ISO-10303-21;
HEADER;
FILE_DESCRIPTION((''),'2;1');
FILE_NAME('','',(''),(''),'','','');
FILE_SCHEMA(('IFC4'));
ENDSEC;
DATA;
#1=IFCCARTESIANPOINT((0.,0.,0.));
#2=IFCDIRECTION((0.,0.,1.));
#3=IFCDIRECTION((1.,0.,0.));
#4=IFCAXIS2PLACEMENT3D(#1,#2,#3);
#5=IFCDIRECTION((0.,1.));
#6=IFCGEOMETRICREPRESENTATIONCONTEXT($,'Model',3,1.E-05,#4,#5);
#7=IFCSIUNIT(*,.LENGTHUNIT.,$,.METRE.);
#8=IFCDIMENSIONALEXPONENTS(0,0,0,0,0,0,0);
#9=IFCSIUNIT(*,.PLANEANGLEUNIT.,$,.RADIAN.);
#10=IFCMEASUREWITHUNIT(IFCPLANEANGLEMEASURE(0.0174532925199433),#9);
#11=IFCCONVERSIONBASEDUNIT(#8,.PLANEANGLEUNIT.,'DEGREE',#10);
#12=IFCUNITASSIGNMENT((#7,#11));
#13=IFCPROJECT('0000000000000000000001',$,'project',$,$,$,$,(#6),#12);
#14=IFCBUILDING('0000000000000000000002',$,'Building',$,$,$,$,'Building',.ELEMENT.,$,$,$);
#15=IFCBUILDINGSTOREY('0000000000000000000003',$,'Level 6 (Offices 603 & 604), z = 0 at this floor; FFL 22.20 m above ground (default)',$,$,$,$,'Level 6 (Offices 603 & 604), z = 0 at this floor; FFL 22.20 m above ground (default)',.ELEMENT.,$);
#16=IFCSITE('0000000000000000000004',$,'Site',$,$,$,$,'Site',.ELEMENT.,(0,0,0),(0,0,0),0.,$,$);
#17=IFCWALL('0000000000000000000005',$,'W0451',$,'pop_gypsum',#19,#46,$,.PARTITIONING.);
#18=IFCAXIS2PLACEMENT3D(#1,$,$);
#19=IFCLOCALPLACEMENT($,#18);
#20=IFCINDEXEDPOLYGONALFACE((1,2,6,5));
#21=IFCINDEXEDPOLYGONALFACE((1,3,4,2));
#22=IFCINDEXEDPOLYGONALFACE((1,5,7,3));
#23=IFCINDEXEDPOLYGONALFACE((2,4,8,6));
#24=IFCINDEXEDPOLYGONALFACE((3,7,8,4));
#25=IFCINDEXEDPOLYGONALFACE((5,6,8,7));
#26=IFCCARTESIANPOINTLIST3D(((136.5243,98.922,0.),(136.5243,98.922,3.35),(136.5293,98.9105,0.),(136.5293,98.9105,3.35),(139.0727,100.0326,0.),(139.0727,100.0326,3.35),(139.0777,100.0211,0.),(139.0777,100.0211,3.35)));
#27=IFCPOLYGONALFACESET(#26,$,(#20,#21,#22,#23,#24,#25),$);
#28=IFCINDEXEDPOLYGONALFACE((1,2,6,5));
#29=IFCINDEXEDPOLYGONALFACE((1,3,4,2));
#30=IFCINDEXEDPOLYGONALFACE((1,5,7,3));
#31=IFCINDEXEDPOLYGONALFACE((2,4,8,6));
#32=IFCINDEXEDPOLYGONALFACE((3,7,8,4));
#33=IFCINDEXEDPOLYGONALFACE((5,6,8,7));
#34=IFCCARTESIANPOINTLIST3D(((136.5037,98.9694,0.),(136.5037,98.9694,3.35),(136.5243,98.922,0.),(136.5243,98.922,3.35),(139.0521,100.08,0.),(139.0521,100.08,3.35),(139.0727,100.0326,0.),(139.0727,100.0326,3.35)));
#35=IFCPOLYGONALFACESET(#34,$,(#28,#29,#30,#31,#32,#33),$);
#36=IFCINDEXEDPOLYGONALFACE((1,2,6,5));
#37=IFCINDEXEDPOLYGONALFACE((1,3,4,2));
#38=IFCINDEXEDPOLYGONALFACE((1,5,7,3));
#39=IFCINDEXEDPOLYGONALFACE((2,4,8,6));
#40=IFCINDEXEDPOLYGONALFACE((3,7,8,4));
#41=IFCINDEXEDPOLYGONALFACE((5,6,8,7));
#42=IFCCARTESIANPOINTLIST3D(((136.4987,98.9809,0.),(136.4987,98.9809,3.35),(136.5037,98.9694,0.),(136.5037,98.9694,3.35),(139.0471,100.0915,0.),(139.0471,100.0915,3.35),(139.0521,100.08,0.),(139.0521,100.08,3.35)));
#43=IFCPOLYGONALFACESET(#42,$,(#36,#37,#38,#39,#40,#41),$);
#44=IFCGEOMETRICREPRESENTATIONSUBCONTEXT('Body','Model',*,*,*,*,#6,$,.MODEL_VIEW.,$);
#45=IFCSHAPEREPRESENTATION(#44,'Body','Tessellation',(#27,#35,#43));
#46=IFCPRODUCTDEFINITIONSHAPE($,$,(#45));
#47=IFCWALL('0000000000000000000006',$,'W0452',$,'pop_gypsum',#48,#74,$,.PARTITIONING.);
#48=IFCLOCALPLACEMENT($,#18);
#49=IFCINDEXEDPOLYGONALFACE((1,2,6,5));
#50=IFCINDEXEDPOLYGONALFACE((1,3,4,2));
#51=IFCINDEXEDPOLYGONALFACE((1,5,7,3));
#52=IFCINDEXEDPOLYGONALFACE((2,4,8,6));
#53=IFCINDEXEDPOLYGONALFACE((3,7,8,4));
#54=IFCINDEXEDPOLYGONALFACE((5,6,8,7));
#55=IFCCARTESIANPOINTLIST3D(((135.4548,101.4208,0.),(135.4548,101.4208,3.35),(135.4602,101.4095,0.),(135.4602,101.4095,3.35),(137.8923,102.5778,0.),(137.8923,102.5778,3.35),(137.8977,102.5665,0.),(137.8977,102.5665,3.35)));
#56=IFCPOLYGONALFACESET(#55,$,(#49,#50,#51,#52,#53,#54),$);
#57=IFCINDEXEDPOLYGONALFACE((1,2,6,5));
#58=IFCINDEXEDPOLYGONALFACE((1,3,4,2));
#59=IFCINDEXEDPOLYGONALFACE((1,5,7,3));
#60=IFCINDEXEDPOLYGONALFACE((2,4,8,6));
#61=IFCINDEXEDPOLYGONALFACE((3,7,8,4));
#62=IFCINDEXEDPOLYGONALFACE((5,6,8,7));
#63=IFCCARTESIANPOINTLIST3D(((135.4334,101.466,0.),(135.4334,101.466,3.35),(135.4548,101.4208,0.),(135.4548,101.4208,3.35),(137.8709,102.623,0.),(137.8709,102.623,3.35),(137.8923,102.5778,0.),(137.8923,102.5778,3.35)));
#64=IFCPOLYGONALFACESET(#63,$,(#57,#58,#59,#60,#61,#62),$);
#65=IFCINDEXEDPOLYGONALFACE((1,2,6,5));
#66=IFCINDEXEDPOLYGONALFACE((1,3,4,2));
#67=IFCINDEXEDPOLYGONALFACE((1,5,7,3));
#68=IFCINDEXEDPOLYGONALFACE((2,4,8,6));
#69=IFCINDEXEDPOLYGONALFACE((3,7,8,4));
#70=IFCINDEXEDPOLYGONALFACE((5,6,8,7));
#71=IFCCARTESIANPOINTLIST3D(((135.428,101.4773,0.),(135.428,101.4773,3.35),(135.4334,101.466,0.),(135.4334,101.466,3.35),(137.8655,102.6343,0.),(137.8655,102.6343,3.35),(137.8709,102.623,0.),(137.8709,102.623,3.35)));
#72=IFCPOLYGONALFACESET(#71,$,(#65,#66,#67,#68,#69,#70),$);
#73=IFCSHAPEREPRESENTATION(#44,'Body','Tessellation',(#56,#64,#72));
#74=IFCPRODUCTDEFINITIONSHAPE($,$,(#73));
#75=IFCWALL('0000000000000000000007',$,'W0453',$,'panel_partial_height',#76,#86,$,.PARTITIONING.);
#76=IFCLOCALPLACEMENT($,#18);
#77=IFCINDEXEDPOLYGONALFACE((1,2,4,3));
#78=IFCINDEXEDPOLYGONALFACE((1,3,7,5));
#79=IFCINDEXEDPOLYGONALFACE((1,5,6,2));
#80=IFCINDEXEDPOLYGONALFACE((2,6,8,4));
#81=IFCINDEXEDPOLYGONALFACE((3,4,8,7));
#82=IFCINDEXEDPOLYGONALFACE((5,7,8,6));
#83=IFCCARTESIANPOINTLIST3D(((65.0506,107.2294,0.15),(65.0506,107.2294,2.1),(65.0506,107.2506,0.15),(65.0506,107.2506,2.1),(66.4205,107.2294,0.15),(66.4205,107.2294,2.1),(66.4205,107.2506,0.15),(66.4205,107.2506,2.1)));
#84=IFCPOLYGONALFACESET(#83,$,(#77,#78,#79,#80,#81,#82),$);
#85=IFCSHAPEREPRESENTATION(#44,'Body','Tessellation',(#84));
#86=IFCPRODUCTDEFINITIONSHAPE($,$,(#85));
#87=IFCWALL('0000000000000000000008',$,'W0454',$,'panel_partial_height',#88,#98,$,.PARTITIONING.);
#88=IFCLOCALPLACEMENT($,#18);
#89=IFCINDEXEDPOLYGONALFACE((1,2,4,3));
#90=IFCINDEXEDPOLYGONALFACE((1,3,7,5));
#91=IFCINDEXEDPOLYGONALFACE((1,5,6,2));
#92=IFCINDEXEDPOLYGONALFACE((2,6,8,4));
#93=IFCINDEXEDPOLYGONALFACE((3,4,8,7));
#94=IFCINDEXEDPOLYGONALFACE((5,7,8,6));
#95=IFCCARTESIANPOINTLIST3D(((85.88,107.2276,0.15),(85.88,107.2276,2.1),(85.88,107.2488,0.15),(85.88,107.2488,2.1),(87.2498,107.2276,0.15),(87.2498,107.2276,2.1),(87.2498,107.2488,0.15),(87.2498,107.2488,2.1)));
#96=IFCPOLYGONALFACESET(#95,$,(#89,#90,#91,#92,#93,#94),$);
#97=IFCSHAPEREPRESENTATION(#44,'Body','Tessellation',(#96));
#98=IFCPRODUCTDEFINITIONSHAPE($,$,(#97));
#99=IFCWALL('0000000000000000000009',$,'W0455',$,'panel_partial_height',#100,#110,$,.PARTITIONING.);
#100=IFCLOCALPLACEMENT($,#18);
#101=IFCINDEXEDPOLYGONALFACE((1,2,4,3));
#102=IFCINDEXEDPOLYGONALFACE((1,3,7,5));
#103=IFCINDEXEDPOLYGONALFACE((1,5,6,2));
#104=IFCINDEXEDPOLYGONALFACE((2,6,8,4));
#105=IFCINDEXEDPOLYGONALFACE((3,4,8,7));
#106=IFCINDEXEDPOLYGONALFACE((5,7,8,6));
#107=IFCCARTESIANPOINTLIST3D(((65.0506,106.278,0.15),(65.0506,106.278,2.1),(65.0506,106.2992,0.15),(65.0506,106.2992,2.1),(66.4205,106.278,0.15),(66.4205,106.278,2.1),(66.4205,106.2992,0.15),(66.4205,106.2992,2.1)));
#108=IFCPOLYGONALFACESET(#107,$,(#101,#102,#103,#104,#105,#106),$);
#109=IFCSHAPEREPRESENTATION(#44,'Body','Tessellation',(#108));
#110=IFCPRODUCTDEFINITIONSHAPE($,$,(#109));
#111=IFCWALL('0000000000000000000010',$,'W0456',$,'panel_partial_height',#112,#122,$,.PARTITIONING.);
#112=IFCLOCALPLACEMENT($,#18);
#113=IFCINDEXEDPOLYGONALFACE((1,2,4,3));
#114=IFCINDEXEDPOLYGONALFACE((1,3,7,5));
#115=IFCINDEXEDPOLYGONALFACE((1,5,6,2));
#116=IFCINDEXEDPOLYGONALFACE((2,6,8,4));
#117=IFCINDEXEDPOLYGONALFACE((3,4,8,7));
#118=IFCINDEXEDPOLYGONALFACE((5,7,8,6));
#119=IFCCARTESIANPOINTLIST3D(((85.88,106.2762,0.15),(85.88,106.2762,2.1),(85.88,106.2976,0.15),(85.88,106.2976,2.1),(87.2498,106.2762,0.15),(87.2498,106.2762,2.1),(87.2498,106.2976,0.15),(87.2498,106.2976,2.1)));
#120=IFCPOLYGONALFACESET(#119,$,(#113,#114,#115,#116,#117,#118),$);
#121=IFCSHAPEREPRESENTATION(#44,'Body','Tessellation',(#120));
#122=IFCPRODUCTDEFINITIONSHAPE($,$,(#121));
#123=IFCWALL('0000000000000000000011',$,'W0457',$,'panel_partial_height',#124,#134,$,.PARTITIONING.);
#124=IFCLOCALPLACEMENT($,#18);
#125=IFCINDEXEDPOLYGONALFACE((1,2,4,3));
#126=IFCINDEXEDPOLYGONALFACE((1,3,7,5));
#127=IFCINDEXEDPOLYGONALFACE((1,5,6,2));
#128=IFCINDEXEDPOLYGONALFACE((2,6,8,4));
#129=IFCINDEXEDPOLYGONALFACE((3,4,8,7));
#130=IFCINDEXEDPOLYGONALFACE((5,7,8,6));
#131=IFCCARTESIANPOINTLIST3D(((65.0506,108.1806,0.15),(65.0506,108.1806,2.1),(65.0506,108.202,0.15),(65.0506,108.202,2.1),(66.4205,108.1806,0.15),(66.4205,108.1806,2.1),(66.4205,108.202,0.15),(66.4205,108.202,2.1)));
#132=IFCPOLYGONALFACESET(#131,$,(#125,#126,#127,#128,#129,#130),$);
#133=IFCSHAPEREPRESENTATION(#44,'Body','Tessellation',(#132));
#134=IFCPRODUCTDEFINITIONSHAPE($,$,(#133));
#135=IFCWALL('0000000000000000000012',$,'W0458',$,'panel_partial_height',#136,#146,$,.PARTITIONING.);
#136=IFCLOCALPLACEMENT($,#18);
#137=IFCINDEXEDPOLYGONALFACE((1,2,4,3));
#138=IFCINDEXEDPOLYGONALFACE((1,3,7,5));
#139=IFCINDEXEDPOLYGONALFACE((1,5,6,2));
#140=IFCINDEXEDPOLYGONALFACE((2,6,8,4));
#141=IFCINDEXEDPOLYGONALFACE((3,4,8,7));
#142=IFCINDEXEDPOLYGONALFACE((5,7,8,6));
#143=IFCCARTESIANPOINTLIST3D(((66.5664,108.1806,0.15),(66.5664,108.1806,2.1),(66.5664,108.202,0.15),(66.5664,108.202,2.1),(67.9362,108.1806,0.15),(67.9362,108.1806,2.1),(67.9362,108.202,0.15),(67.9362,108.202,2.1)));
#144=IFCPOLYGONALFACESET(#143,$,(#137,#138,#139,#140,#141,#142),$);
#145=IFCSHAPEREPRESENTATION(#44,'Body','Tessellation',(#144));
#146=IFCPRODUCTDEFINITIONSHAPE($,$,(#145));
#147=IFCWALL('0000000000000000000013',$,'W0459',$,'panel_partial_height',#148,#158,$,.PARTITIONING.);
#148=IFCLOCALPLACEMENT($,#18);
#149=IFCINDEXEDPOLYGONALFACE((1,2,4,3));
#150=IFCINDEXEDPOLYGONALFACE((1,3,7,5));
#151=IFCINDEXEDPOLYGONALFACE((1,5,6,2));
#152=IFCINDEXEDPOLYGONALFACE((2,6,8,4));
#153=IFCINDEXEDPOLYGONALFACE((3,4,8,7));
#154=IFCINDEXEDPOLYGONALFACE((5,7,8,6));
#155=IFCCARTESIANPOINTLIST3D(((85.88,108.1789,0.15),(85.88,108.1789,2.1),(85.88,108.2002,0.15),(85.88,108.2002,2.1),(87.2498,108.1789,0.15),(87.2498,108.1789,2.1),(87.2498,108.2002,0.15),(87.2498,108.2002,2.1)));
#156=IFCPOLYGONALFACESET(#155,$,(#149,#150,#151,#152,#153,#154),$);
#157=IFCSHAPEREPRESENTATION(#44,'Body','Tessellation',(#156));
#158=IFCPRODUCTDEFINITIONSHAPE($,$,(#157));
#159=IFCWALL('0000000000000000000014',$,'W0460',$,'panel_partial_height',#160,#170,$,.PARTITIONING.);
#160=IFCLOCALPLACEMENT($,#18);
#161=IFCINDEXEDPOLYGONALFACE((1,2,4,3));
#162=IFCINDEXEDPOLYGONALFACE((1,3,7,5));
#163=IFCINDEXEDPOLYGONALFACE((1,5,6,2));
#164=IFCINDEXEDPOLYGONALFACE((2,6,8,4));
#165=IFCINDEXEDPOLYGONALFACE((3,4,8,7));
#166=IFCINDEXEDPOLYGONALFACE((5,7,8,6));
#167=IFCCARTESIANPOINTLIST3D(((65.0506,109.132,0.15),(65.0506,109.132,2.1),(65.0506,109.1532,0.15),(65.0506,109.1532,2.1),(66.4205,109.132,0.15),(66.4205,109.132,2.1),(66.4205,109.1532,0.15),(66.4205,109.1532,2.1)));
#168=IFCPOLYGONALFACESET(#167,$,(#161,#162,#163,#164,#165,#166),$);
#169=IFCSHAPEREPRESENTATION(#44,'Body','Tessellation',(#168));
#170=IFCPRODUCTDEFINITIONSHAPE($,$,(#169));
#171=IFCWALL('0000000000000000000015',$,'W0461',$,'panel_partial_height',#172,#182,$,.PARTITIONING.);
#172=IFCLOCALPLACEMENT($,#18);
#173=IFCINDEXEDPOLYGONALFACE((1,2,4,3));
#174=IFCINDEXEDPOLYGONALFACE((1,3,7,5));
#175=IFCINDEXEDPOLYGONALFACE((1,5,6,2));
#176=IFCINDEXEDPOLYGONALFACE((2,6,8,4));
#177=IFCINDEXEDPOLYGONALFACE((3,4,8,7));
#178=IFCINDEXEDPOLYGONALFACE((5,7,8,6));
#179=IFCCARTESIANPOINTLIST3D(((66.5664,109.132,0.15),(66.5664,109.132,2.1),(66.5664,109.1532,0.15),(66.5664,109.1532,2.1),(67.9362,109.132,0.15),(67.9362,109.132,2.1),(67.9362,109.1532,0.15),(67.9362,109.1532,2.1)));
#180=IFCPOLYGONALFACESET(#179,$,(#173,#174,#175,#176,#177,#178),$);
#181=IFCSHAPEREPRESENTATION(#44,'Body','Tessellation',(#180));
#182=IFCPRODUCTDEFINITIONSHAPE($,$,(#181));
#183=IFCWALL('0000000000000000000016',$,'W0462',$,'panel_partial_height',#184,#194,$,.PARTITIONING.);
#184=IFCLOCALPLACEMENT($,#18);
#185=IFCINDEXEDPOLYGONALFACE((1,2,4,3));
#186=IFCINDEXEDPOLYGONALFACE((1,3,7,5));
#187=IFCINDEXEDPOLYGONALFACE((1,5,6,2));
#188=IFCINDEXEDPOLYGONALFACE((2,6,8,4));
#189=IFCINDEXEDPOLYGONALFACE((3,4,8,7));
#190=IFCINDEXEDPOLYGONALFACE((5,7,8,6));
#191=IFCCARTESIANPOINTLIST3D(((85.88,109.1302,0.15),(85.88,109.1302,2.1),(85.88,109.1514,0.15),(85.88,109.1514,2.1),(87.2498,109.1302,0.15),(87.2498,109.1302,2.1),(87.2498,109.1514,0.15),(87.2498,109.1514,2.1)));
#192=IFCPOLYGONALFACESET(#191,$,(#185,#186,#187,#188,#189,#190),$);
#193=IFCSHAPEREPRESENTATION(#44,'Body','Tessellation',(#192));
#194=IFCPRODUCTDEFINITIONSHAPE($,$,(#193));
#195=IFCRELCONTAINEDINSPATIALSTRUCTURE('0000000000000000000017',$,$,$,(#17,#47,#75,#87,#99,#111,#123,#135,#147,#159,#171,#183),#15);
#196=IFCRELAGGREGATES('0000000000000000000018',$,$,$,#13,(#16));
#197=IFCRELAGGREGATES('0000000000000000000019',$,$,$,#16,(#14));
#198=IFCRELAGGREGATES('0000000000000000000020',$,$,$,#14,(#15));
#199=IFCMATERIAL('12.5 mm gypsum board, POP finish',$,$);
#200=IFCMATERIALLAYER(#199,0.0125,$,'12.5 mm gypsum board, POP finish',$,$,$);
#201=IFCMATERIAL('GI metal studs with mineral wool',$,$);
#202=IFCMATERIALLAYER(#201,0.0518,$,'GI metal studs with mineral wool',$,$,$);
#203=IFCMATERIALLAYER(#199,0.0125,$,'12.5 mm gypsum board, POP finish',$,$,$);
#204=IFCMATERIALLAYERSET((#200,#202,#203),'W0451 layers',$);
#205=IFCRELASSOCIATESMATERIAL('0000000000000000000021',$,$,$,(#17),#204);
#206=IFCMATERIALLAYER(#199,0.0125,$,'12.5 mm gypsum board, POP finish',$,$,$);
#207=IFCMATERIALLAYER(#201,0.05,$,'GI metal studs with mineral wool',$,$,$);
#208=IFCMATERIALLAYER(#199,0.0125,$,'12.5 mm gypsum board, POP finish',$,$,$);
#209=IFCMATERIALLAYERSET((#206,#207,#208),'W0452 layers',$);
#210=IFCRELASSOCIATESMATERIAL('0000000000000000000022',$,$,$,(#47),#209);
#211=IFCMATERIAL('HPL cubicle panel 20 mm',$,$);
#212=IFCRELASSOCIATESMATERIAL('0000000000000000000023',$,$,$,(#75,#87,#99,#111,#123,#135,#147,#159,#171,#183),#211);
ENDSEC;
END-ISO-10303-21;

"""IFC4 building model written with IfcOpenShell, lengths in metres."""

from ifc_helpers import new_model, entity, si_unit, converted_unit, direction, frame, frame_2d, origin_with_axes, origin_2d_with_axis, place, context, subcontext, project, spatial, rectangle, extrude, material, layer, layer_set, layer_usage, element, save


model = new_model("IFC4")

# Units and contexts
model_context = context("Model", 3, precision=1e-05, world=origin_with_axes(), true_north=direction((0.0, 1.0)))
body_context = subcontext(model_context, "Body", "Model", "MODEL_VIEW")
ifc_project = project(units=[si_unit("LENGTHUNIT", "METRE"), converted_unit("PLANEANGLEUNIT", "DEGREE", entity("IfcPlaneAngleMeasure", 0.0174532925199433), si_unit("PLANEANGLEUNIT", "RADIAN"), dimensions=[0, 0, 0, 0, 0, 0, 0])], contexts=[model_context])

# Site, building, storey
site = spatial("IfcSite", under=ifc_project, Name="Site", LongName="Site", CompositionType="ELEMENT", RefLatitude=(0, 0, 0), RefLongitude=(0, 0, 0), RefElevation=0.0)
building = spatial("IfcBuilding", under=site, Name="Building", LongName="Building", CompositionType="ELEMENT")
storey = spatial("IfcBuildingStorey", under=building, Name="Level 6 (Offices 603 & 604), z = 0 at this floor; FFL 22.20 m above ground (default)", LongName="Level 6 (Offices 603 & 604), z = 0 at this floor; FFL 22.20 m above ground (default)", CompositionType="ELEMENT")

# Walls
ifc_material_1 = material(Name="12.5 mm gypsum board, POP finish")
ifc_layer_1 = layer(ifc_material_1, 0.0125, Name="12.5 mm gypsum board, POP finish")
ifc_material_2 = material(Name="GI metal studs with mineral wool")
ifc_layer_2 = layer(ifc_material_2, 0.0518, Name="GI metal studs with mineral wool")
ifc_layer_3 = layer(ifc_material_1, 0.0125, Name="12.5 mm gypsum board, POP finish")
ifc_layer_set_1 = layer_set([ifc_layer_1, ifc_layer_2, ifc_layer_3], Name="W0451 layers")
ifc_layer_usage_1 = layer_usage(ifc_layer_set_1, "AXIS2", "POSITIVE", -0.0384)
placement = place(None, origin_with_axes())
element("IfcWall", 1, at=placement, inside=storey, material=ifc_layer_usage_1, Name="W0451", ObjectType="pop_gypsum", PredefinedType="PARTITIONING", context=body_context, shape_type="SweptSolid", body=[
    extrude(rectangle(XDim=2.7799, YDim=0.0125, at=frame_2d((0.0, 0.0), x_axis=(0.916728, 0.399513))), frame((137.801, 99.4715, 0.0), z_axis=(0.0, 0.0, 1.0), x_axis=(1.0, 0.0, 0.0)), (0.0, 0.0, 1.0), 3.35),
    extrude(rectangle(XDim=2.7799, YDim=0.0518, at=frame_2d((-0.0128, 0.0295), x_axis=(0.916728, 0.399513))), frame((137.801, 99.4715, 0.0), z_axis=(0.0, 0.0, 1.0), x_axis=(1.0, 0.0, 0.0)), (0.0, 0.0, 1.0), 3.35),
    extrude(rectangle(XDim=2.7799, YDim=0.0125, at=frame_2d((-0.0257, 0.0589), x_axis=(0.916728, 0.399513))), frame((137.801, 99.4715, 0.0), z_axis=(0.0, 0.0, 1.0), x_axis=(1.0, 0.0, 0.0)), (0.0, 0.0, 1.0), 3.35),
])
ifc_layer_4 = layer(ifc_material_1, 0.0125, Name="12.5 mm gypsum board, POP finish")
ifc_layer_5 = layer(ifc_material_2, 0.05, Name="GI metal studs with mineral wool")
ifc_layer_6 = layer(ifc_material_1, 0.0125, Name="12.5 mm gypsum board, POP finish")
ifc_layer_set_2 = layer_set([ifc_layer_4, ifc_layer_5, ifc_layer_6], Name="W0452 layers")
ifc_layer_usage_2 = layer_usage(ifc_layer_set_2, "AXIS2", "POSITIVE", -0.0375)
element("IfcWall", 2, at=placement, inside=storey, material=ifc_layer_usage_2, Name="W0452", ObjectType="pop_gypsum", PredefinedType="PARTITIONING", context=body_context, shape_type="SweptSolid", body=[
    extrude(rectangle(XDim=2.6982, YDim=0.0125, at=frame_2d((0.0, 0.0), x_axis=(0.903394, 0.428811))), frame((136.6763, 101.9937, 0.0), z_axis=(0.0, 0.0, 1.0), x_axis=(1.0, 0.0, 0.0)), (0.0, 0.0, 1.0), 3.35),
    extrude(rectangle(XDim=2.6982, YDim=0.05, at=frame_2d((-0.0134, 0.0282), x_axis=(0.903394, 0.428811))), frame((136.6763, 101.9937, 0.0), z_axis=(0.0, 0.0, 1.0), x_axis=(1.0, 0.0, 0.0)), (0.0, 0.0, 1.0), 3.35),
    extrude(rectangle(XDim=2.6982, YDim=0.0125, at=frame_2d((-0.0268, 0.0565), x_axis=(0.903394, 0.428811))), frame((136.6763, 101.9937, 0.0), z_axis=(0.0, 0.0, 1.0), x_axis=(1.0, 0.0, 0.0)), (0.0, 0.0, 1.0), 3.35),
])
ifc_material_3 = material(Name="HPL cubicle panel 20 mm")
element("IfcWall", 3, at=placement, inside=storey, material=ifc_material_3, Name="W0453", ObjectType="panel_partial_height", PredefinedType="PARTITIONING", context=body_context, shape_type="SweptSolid", body=[
    extrude(rectangle(XDim=1.3699, YDim=0.0213, at=origin_2d_with_axis()), frame((65.7356, 107.24, 0.15), z_axis=(0.0, 0.0, 1.0), x_axis=(1.0, 0.0, 0.0)), (0.0, 0.0, 1.0), 1.95),
])
element("IfcWall", 4, at=placement, inside=storey, material=ifc_material_3, Name="W0454", ObjectType="panel_partial_height", PredefinedType="PARTITIONING", context=body_context, shape_type="SweptSolid", body=[
    extrude(rectangle(XDim=1.3698, YDim=0.0213, at=frame_2d((0.0, 0.0), x_axis=(1.0, 0.0))), frame((86.5649, 107.2382, 0.15), z_axis=(0.0, 0.0, 1.0), x_axis=(1.0, 0.0, 0.0)), (0.0, 0.0, 1.0), 1.95),
])
element("IfcWall", 5, at=placement, inside=storey, material=ifc_material_3, Name="W0455", ObjectType="panel_partial_height", PredefinedType="PARTITIONING", context=body_context, shape_type="SweptSolid", body=[
    extrude(rectangle(XDim=1.3699, YDim=0.0213, at=origin_2d_with_axis()), frame((65.7356, 106.2886, 0.15), z_axis=(0.0, 0.0, 1.0), x_axis=(1.0, 0.0, 0.0)), (0.0, 0.0, 1.0), 1.95),
])
element("IfcWall", 6, at=placement, inside=storey, material=ifc_material_3, Name="W0456", ObjectType="panel_partial_height", PredefinedType="PARTITIONING", context=body_context, shape_type="SweptSolid", body=[
    extrude(rectangle(XDim=1.3698, YDim=0.0213, at=frame_2d((0.0, 0.0), x_axis=(1.0, 0.0))), frame((86.5649, 106.2869, 0.15), z_axis=(0.0, 0.0, 1.0), x_axis=(1.0, 0.0, 0.0)), (0.0, 0.0, 1.0), 1.95),
])
element("IfcWall", 7, at=placement, inside=storey, material=ifc_material_3, Name="W0457", ObjectType="panel_partial_height", PredefinedType="PARTITIONING", context=body_context, shape_type="SweptSolid", body=[
    extrude(rectangle(XDim=1.3699, YDim=0.0213, at=origin_2d_with_axis()), frame((65.7356, 108.1913, 0.15), z_axis=(0.0, 0.0, 1.0), x_axis=(1.0, 0.0, 0.0)), (0.0, 0.0, 1.0), 1.95),
])
element("IfcWall", 8, at=placement, inside=storey, material=ifc_material_3, Name="W0458", ObjectType="panel_partial_height", PredefinedType="PARTITIONING", context=body_context, shape_type="SweptSolid", body=[
    extrude(rectangle(XDim=1.3698, YDim=0.0213, at=frame_2d((0.0, 0.0), x_axis=(1.0, 0.0))), frame((67.2513, 108.1913, 0.15), z_axis=(0.0, 0.0, 1.0), x_axis=(1.0, 0.0, 0.0)), (0.0, 0.0, 1.0), 1.95),
])
element("IfcWall", 9, at=placement, inside=storey, material=ifc_material_3, Name="W0459", ObjectType="panel_partial_height", PredefinedType="PARTITIONING", context=body_context, shape_type="SweptSolid", body=[
    extrude(rectangle(XDim=1.3698, YDim=0.0213, at=frame_2d((0.0, 0.0), x_axis=(1.0, 0.0))), frame((86.5649, 108.1895, 0.15), z_axis=(0.0, 0.0, 1.0), x_axis=(1.0, 0.0, 0.0)), (0.0, 0.0, 1.0), 1.95),
])
element("IfcWall", 10, at=placement, inside=storey, material=ifc_material_3, Name="W0460", ObjectType="panel_partial_height", PredefinedType="PARTITIONING", context=body_context, shape_type="SweptSolid", body=[
    extrude(rectangle(XDim=1.3699, YDim=0.0213, at=origin_2d_with_axis()), frame((65.7356, 109.1426, 0.15), z_axis=(0.0, 0.0, 1.0), x_axis=(1.0, 0.0, 0.0)), (0.0, 0.0, 1.0), 1.95),
])
element("IfcWall", 11, at=placement, inside=storey, material=ifc_material_3, Name="W0461", ObjectType="panel_partial_height", PredefinedType="PARTITIONING", context=body_context, shape_type="SweptSolid", body=[
    extrude(rectangle(XDim=1.3698, YDim=0.0213, at=frame_2d((0.0, 0.0), x_axis=(1.0, 0.0))), frame((67.2513, 109.1426, 0.15), z_axis=(0.0, 0.0, 1.0), x_axis=(1.0, 0.0, 0.0)), (0.0, 0.0, 1.0), 1.95),
])
element("IfcWall", 12, at=placement, inside=storey, material=ifc_material_3, Name="W0462", ObjectType="panel_partial_height", PredefinedType="PARTITIONING", context=body_context, shape_type="SweptSolid", body=[
    extrude(rectangle(XDim=1.3698, YDim=0.0213, at=frame_2d((0.0, 0.0), x_axis=(1.0, 0.0))), frame((86.5649, 109.1408, 0.15), z_axis=(0.0, 0.0, 1.0), x_axis=(1.0, 0.0, 0.0)), (0.0, 0.0, 1.0), 1.95),
])

save(model, "model.ifc")
